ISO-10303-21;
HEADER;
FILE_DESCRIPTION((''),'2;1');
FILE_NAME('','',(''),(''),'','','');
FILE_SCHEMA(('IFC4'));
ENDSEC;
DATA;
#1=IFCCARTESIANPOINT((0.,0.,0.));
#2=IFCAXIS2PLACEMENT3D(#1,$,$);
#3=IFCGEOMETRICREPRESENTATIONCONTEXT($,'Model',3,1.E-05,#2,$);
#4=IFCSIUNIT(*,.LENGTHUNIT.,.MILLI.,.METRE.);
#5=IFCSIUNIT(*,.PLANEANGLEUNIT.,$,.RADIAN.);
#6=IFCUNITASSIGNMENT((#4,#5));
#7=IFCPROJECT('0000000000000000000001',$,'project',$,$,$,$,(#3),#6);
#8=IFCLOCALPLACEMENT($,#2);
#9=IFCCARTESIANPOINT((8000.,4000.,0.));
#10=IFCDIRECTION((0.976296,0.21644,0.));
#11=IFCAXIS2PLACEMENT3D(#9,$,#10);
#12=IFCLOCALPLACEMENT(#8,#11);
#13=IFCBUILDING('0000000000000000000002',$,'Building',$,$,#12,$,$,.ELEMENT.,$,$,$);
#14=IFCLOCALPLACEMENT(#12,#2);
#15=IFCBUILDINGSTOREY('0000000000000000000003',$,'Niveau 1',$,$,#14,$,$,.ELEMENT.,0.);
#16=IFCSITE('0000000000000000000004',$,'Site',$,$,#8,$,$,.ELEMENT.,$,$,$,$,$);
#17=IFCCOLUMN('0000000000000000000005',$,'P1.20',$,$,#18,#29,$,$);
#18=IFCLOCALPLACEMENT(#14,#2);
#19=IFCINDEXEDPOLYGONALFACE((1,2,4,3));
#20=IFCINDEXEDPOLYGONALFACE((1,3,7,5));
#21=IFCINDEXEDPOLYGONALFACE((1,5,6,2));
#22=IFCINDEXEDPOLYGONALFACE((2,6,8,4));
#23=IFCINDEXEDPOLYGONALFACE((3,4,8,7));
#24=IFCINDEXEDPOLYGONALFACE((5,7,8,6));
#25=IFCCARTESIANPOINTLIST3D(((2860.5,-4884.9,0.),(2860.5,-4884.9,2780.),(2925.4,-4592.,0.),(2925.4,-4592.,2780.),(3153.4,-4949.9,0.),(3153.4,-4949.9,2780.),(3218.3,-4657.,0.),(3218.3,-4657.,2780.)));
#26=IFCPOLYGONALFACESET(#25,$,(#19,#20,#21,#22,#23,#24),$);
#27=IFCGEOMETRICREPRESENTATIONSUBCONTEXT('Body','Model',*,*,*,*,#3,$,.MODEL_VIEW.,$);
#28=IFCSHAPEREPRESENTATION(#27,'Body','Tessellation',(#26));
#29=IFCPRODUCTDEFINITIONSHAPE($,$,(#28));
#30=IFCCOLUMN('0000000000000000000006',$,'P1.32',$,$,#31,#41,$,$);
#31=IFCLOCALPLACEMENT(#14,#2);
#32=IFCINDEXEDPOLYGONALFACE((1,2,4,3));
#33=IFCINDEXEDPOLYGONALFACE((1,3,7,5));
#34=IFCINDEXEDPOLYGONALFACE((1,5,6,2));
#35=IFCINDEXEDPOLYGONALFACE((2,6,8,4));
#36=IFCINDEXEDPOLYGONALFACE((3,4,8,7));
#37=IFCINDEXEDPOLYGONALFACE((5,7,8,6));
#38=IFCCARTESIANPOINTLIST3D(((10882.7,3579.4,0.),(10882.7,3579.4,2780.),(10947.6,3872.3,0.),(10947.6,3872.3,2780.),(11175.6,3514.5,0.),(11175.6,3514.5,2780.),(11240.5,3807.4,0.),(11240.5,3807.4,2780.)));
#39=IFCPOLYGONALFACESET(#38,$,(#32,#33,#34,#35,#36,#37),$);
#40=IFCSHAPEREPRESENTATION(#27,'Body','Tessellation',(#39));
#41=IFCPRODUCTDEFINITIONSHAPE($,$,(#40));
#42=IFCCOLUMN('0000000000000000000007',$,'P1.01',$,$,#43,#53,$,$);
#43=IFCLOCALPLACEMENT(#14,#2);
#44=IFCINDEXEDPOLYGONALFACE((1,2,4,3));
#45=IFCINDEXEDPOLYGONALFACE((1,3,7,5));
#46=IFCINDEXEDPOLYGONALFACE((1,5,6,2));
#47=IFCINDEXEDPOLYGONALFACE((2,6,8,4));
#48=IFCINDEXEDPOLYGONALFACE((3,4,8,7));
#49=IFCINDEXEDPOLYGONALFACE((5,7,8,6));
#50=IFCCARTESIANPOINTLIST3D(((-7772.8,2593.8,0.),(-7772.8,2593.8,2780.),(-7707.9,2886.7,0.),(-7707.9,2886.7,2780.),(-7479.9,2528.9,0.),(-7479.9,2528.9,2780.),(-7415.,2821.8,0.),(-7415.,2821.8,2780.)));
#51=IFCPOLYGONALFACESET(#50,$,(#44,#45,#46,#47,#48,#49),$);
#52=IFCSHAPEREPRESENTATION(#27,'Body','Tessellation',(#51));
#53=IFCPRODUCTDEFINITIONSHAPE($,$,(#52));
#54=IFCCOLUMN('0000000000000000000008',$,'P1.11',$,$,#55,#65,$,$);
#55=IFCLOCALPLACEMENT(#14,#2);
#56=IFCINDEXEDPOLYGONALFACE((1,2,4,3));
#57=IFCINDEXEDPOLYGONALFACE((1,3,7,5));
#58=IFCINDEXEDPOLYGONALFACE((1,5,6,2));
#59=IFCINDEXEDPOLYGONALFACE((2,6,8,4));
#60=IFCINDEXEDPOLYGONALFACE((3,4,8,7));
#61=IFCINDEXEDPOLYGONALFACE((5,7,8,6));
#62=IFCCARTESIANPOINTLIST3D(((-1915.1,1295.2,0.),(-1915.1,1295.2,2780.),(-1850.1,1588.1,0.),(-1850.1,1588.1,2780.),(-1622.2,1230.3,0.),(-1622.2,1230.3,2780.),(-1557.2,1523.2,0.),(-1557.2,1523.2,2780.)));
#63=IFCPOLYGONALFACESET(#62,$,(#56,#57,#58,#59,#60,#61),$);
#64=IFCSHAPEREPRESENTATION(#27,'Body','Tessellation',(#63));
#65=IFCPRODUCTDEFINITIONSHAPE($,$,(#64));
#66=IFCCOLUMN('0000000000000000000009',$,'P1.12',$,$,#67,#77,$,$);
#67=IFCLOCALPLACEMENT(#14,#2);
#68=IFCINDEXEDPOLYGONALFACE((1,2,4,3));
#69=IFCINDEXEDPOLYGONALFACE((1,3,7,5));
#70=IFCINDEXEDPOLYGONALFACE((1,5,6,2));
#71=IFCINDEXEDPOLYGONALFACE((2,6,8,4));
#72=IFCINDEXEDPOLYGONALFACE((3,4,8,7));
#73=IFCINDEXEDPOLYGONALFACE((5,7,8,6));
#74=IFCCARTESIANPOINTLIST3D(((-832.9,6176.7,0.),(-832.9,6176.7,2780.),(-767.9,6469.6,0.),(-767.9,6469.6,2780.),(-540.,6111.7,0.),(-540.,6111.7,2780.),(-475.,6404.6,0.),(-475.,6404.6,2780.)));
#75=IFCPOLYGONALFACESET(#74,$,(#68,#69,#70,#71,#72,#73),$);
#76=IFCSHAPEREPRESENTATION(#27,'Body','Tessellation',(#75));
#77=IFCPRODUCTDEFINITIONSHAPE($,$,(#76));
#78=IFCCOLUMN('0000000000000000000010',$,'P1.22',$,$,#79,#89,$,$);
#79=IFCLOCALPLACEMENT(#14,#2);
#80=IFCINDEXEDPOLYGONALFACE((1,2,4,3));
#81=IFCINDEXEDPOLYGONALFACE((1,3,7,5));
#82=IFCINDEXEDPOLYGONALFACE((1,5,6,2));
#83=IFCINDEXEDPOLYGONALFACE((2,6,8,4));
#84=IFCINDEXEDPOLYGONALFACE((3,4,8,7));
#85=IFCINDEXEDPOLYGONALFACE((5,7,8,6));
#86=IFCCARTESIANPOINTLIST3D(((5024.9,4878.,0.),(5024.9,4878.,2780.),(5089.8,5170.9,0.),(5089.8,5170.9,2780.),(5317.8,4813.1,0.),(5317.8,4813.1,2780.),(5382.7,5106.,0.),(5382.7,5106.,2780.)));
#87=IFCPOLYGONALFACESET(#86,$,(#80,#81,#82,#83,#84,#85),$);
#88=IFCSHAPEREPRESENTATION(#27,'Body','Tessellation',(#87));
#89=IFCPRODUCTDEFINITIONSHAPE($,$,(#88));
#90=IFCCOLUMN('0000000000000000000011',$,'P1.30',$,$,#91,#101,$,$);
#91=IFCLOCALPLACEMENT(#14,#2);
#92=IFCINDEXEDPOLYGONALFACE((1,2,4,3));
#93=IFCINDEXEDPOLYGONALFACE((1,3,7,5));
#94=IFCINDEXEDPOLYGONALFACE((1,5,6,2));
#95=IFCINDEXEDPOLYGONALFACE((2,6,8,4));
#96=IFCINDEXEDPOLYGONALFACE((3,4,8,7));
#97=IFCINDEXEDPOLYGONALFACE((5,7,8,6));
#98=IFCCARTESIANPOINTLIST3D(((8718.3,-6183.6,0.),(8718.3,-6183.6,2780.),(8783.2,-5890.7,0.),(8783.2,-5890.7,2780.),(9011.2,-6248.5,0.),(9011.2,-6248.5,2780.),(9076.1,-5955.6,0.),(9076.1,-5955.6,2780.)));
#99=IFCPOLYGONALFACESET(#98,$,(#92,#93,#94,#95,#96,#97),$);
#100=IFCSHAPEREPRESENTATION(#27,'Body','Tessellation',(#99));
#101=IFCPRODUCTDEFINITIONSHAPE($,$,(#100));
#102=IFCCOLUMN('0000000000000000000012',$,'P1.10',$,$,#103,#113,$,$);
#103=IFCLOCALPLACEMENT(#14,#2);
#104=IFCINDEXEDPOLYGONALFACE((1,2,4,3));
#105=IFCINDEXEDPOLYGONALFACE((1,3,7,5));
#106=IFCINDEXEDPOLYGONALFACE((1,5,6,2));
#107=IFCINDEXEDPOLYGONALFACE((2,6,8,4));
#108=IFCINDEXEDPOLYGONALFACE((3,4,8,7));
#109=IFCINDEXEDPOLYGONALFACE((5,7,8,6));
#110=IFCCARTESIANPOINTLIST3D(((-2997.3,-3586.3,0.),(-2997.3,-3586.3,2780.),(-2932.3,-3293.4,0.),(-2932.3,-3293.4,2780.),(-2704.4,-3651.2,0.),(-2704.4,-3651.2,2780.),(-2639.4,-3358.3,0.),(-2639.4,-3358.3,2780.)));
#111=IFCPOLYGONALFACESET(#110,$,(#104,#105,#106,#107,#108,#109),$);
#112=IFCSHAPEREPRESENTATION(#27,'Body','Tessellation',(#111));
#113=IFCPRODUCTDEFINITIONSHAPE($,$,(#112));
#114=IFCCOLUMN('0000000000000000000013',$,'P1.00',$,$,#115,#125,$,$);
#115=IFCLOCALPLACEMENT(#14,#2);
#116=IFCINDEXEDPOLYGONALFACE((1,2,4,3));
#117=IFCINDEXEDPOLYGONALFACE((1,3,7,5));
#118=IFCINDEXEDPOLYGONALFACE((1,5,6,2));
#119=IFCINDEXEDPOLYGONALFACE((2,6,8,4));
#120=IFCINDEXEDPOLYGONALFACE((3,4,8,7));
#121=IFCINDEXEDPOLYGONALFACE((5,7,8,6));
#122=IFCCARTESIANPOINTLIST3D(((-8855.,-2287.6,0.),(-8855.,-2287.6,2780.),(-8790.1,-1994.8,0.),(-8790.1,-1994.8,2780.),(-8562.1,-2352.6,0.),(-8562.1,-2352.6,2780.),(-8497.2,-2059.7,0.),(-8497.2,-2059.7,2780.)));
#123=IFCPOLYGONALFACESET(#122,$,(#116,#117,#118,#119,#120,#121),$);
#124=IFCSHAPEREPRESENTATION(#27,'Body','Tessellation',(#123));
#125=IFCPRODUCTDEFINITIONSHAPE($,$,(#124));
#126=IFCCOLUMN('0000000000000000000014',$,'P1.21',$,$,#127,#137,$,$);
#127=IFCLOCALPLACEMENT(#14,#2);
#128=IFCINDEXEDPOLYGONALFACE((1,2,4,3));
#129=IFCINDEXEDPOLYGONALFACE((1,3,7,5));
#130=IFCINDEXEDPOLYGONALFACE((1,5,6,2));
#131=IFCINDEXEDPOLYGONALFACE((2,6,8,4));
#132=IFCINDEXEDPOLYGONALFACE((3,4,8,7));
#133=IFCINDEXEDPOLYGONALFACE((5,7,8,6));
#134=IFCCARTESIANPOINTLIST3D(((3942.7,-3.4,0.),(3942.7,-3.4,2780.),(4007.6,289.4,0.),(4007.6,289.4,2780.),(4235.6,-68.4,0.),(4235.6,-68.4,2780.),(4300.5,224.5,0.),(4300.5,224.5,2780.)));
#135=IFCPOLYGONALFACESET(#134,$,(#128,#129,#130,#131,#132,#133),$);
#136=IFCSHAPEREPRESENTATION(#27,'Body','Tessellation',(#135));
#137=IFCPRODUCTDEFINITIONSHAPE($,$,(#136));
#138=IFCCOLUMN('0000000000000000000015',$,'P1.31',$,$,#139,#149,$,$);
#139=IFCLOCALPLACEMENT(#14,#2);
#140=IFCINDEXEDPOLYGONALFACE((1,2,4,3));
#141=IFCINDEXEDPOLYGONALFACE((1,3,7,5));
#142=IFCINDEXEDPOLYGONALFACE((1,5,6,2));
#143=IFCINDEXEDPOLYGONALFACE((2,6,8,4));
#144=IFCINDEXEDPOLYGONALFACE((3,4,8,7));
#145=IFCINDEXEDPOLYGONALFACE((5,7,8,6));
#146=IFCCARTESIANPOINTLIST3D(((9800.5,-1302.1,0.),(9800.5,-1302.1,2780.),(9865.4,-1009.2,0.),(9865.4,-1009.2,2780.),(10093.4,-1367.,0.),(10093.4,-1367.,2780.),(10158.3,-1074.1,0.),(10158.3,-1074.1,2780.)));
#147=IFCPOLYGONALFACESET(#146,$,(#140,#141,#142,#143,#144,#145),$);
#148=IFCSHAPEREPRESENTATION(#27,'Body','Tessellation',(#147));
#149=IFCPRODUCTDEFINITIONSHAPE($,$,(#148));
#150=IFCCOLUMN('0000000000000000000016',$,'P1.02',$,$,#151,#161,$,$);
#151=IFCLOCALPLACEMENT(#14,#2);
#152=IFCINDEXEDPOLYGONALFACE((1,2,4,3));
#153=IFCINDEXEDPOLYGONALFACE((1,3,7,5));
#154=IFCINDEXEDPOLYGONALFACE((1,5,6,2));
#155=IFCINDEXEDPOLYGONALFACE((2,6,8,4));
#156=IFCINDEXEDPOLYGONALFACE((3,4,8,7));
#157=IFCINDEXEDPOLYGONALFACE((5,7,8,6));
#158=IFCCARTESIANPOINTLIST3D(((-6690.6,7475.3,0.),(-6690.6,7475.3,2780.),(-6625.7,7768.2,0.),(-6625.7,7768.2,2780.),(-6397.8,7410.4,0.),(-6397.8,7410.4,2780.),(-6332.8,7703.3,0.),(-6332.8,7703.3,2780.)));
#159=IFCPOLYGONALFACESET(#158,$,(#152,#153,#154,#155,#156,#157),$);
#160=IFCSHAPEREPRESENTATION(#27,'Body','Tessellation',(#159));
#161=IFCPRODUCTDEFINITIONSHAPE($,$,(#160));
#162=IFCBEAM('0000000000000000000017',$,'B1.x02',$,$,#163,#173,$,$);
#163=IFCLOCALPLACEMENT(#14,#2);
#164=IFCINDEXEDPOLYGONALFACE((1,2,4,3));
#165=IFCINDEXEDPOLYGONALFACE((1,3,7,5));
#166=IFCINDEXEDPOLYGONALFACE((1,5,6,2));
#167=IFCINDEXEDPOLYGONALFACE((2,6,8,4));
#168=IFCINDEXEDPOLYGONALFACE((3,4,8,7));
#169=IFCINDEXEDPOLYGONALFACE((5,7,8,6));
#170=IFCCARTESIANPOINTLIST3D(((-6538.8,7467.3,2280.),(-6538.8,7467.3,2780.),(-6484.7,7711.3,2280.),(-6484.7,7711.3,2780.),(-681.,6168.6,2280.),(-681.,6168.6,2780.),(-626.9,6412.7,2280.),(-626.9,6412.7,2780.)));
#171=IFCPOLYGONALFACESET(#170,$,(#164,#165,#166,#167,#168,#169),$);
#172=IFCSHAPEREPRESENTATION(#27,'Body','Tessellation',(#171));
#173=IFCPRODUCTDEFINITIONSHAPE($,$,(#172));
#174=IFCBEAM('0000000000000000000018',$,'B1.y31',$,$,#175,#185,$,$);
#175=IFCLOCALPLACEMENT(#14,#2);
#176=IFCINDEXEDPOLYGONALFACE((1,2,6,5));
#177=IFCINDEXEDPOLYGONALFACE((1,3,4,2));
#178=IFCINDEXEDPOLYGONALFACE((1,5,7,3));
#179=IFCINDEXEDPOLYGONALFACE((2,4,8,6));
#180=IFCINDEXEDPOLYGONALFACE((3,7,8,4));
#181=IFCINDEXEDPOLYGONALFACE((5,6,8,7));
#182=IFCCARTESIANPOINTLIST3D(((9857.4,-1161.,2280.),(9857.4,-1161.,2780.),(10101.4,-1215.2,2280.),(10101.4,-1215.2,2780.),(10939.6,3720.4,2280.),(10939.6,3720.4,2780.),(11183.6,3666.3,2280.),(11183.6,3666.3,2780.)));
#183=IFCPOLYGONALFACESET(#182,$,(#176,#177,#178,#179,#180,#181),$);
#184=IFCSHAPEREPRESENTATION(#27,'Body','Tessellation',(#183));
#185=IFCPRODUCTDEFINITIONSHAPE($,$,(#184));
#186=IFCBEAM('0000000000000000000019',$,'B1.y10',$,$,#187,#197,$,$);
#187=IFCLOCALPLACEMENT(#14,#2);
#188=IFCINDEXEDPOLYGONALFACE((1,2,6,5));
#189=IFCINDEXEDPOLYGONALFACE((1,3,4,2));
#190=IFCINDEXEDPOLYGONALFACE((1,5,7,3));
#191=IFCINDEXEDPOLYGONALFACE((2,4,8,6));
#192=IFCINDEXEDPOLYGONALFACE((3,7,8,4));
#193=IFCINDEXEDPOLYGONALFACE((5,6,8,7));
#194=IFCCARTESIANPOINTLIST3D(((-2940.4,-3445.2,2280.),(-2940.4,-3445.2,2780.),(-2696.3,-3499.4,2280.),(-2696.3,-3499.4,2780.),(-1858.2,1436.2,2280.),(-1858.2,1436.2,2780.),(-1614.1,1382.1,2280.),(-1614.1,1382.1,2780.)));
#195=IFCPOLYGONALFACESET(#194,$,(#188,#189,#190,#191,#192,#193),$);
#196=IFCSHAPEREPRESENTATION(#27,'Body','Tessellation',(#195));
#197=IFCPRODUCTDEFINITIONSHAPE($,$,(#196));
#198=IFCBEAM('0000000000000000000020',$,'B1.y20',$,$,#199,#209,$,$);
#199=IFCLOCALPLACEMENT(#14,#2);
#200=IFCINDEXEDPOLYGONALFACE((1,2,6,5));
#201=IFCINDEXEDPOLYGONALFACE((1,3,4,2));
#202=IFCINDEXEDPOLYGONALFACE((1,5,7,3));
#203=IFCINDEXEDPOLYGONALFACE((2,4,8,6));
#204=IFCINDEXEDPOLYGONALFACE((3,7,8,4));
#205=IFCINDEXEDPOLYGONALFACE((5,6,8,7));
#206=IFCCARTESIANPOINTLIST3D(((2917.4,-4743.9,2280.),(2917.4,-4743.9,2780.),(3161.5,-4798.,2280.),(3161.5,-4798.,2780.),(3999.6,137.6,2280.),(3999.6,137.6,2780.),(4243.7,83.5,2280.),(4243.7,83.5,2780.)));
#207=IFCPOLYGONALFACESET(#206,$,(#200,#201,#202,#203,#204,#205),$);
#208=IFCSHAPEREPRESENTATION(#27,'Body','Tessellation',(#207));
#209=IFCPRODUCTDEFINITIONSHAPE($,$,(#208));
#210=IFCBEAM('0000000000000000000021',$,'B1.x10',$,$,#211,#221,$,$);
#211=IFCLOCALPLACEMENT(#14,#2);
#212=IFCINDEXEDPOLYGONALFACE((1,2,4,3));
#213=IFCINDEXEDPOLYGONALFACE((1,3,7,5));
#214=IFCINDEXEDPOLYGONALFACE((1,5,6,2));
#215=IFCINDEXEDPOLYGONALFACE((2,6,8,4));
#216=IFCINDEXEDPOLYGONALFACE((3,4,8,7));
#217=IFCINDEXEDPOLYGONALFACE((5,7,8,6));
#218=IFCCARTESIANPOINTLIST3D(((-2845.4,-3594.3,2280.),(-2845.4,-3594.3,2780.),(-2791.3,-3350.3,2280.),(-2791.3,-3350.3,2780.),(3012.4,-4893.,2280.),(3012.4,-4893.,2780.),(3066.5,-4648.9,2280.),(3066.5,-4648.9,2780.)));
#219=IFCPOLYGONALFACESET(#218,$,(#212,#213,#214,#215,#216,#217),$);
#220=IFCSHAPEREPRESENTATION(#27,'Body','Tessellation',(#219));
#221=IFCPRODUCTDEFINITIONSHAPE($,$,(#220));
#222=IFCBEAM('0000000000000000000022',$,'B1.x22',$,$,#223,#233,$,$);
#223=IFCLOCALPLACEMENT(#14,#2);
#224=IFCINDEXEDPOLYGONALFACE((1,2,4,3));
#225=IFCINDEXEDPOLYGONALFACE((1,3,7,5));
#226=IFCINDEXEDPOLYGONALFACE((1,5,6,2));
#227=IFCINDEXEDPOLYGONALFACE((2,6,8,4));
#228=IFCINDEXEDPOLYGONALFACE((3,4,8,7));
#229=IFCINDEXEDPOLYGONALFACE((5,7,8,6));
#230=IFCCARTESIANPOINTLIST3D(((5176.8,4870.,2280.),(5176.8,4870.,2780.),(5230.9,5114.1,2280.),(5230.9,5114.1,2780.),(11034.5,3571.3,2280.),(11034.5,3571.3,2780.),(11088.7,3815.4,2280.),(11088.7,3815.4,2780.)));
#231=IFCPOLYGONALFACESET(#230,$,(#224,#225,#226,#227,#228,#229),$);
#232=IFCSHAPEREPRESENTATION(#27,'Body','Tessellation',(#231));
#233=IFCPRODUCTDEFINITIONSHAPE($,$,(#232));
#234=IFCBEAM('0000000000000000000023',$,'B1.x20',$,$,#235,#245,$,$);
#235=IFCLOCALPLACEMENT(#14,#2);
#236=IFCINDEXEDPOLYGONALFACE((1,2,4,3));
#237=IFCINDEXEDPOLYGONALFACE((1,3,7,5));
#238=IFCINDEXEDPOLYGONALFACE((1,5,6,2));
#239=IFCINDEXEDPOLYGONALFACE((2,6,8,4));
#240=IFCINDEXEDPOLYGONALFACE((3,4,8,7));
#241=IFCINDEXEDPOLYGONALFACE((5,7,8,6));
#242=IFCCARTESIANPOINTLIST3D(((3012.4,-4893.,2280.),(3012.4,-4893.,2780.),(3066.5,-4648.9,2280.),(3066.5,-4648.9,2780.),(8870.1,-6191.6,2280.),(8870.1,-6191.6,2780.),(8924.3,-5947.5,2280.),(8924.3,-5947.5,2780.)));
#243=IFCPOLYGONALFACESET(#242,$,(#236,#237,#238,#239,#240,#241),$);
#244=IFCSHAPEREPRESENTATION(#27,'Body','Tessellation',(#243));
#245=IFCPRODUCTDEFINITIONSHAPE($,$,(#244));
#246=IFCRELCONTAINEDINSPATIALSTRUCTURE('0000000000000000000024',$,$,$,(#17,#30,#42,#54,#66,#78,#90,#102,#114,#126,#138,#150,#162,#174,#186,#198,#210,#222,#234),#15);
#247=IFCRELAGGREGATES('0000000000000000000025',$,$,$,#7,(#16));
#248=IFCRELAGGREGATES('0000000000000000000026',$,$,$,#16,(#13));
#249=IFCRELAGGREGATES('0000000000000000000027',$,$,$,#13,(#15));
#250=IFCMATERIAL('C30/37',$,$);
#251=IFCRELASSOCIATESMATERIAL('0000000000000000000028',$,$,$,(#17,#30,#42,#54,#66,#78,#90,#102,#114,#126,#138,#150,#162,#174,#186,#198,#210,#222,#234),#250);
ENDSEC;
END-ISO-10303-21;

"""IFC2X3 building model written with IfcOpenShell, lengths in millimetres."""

from ifc_helpers import new_model, si_unit, frame, origin, origin_2d, place, context, subcontext, project, spatial, rectangle, extrude, material, element, save


model = new_model("IFC2X3")

# Units and contexts
model_context = context("Model", 3, precision=1e-05, world=origin())
body_context = subcontext(model_context, "Body", "Model", "MODEL_VIEW")
ifc_project = project(units=[si_unit("LENGTHUNIT", "METRE", prefix="MILLI"), si_unit("PLANEANGLEUNIT", "RADIAN")], contexts=[model_context])

# Site, building, storey
site_placement = place(None, origin())
site = spatial("IfcSite", under=ifc_project, at=site_placement, Name="Site", CompositionType="ELEMENT")
building_placement = place(site_placement, frame((8000.0, 4000.0, 0.0), x_axis=(0.976296, 0.21644, 0.0)))
building = spatial("IfcBuilding", under=site, at=building_placement, Name="Building", CompositionType="ELEMENT")
storey_placement = place(building_placement, origin())
storey = spatial("IfcBuildingStorey", under=building, at=storey_placement, Name="Niveau 1", CompositionType="ELEMENT", Elevation=0.0)

# Columns
ifc_material = material(Name="C30/37")
for number, where, z_axis, x_axis, name in (
    (1, (3039.4, -4770.9, 0.0), (0.0, 0.0, 1.0), (0.976296, -0.21644, 0.0), "P1.20"),
    (2, (11061.6, 3693.4, 0.0), (0.0, 0.0, 1.0), (0.976296, -0.21644, 0.0), "P1.32"),
    (3, (-7593.9, 2707.8, 0.0), (0.0, 0.0, 1.0), (0.976296, -0.21644, 0.0), "P1.01"),
    (4, (-1736.2, 1409.2, 0.0), (0.0, 0.0, 1.0), (0.976296, -0.21644, 0.0), "P1.11"),
    (5, (-654.0, 6290.7, 0.0), (0.0, 0.0, 1.0), (0.976296, -0.21644, 0.0), "P1.12"),
    (6, (5203.8, 4992.0, 0.0), (0.0, 0.0, 1.0), (0.976296, -0.21644, 0.0), "P1.22"),
    (7, (8897.2, -6069.6, 0.0), (0.0, 0.0, 1.0), (0.976296, -0.21644, 0.0), "P1.30"),
    (8, (-2818.4, -3472.3, 0.0), (0.0, 0.0, 1.0), (0.976296, -0.21644, 0.0), "P1.10"),
    (9, (-8676.1, -2173.7, 0.0), (0.0, 0.0, 1.0), (0.976296, -0.21644, 0.0), "P1.00"),
    (10, (4121.6, 110.5, 0.0), (0.0, 0.0, 1.0), (0.976296, -0.21644, 0.0), "P1.21"),
    (11, (9979.4, -1188.1, 0.0), (0.0, 0.0, 1.0), (0.976296, -0.21644, 0.0), "P1.31"),
    (12, (-6511.7, 7589.3, 0.0), (0.0, 0.0, 1.0), (0.976296, -0.21644, 0.0), "P1.02"),
):
    element("IfcColumn", number, at=place(storey_placement, frame(where, z_axis=z_axis, x_axis=x_axis)), inside=storey, material=ifc_material, Name=name, context=body_context, shape_type="SweptSolid", body=[
        extrude(rectangle(XDim=300.0, YDim=300.0, at=origin_2d()), origin(), (0.0, 0.0, 1.0), 2780.0),
    ])

# Beams
beam_1_placement = place(storey_placement, frame((-6511.7, 7589.3, 2530.0), z_axis=(0.976296, -0.21644, 0.0), x_axis=(0.21644, 0.976296, 0.0)))
element("IfcBeam", 13, at=beam_1_placement, inside=storey, material=ifc_material, Name="B1.x02", context=body_context, shape_type="SweptSolid", body=[
    extrude(rectangle(XDim=250.0, YDim=500.0, at=origin_2d()), origin(), (0.0, 0.0, 1.0), 6000.0),
])
for number, where, z_axis, x_axis, name in (
    (14, (9979.4, -1188.1, 2530.0), (0.21644, 0.976296, 0.0), (-0.976296, 0.21644, 0.0), "B1.y31"),
    (15, (-2818.4, -3472.3, 2530.0), (0.21644, 0.976296, 0.0), (-0.976296, 0.21644, 0.0), "B1.y10"),
    (16, (3039.4, -4770.9, 2530.0), (0.21644, 0.976296, 0.0), (-0.976296, 0.21644, 0.0), "B1.y20"),
):
    element("IfcBeam", number, at=place(storey_placement, frame(where, z_axis=z_axis, x_axis=x_axis)), inside=storey, material=ifc_material, Name=name, context=body_context, shape_type="SweptSolid", body=[
        extrude(rectangle(XDim=250.0, YDim=500.0, at=origin_2d()), origin(), (0.0, 0.0, 1.0), 5000.0),
    ])
for number, where, z_axis, x_axis, name in (
    (17, (-2818.4, -3472.3, 2530.0), (0.976296, -0.21644, 0.0), (0.21644, 0.976296, 0.0), "B1.x10"),
    (18, (5203.8, 4992.0, 2530.0), (0.976296, -0.21644, 0.0), (0.21644, 0.976296, 0.0), "B1.x22"),
    (19, (3039.4, -4770.9, 2530.0), (0.976296, -0.21644, 0.0), (0.21644, 0.976296, 0.0), "B1.x20"),
):
    element("IfcBeam", number, at=place(storey_placement, frame(where, z_axis=z_axis, x_axis=x_axis)), inside=storey, material=ifc_material, Name=name, context=body_context, shape_type="SweptSolid", body=[
        extrude(rectangle(XDim=250.0, YDim=500.0, at=origin_2d()), origin(), (0.0, 0.0, 1.0), 6000.0),
    ])

save(model, "model.ifc")
